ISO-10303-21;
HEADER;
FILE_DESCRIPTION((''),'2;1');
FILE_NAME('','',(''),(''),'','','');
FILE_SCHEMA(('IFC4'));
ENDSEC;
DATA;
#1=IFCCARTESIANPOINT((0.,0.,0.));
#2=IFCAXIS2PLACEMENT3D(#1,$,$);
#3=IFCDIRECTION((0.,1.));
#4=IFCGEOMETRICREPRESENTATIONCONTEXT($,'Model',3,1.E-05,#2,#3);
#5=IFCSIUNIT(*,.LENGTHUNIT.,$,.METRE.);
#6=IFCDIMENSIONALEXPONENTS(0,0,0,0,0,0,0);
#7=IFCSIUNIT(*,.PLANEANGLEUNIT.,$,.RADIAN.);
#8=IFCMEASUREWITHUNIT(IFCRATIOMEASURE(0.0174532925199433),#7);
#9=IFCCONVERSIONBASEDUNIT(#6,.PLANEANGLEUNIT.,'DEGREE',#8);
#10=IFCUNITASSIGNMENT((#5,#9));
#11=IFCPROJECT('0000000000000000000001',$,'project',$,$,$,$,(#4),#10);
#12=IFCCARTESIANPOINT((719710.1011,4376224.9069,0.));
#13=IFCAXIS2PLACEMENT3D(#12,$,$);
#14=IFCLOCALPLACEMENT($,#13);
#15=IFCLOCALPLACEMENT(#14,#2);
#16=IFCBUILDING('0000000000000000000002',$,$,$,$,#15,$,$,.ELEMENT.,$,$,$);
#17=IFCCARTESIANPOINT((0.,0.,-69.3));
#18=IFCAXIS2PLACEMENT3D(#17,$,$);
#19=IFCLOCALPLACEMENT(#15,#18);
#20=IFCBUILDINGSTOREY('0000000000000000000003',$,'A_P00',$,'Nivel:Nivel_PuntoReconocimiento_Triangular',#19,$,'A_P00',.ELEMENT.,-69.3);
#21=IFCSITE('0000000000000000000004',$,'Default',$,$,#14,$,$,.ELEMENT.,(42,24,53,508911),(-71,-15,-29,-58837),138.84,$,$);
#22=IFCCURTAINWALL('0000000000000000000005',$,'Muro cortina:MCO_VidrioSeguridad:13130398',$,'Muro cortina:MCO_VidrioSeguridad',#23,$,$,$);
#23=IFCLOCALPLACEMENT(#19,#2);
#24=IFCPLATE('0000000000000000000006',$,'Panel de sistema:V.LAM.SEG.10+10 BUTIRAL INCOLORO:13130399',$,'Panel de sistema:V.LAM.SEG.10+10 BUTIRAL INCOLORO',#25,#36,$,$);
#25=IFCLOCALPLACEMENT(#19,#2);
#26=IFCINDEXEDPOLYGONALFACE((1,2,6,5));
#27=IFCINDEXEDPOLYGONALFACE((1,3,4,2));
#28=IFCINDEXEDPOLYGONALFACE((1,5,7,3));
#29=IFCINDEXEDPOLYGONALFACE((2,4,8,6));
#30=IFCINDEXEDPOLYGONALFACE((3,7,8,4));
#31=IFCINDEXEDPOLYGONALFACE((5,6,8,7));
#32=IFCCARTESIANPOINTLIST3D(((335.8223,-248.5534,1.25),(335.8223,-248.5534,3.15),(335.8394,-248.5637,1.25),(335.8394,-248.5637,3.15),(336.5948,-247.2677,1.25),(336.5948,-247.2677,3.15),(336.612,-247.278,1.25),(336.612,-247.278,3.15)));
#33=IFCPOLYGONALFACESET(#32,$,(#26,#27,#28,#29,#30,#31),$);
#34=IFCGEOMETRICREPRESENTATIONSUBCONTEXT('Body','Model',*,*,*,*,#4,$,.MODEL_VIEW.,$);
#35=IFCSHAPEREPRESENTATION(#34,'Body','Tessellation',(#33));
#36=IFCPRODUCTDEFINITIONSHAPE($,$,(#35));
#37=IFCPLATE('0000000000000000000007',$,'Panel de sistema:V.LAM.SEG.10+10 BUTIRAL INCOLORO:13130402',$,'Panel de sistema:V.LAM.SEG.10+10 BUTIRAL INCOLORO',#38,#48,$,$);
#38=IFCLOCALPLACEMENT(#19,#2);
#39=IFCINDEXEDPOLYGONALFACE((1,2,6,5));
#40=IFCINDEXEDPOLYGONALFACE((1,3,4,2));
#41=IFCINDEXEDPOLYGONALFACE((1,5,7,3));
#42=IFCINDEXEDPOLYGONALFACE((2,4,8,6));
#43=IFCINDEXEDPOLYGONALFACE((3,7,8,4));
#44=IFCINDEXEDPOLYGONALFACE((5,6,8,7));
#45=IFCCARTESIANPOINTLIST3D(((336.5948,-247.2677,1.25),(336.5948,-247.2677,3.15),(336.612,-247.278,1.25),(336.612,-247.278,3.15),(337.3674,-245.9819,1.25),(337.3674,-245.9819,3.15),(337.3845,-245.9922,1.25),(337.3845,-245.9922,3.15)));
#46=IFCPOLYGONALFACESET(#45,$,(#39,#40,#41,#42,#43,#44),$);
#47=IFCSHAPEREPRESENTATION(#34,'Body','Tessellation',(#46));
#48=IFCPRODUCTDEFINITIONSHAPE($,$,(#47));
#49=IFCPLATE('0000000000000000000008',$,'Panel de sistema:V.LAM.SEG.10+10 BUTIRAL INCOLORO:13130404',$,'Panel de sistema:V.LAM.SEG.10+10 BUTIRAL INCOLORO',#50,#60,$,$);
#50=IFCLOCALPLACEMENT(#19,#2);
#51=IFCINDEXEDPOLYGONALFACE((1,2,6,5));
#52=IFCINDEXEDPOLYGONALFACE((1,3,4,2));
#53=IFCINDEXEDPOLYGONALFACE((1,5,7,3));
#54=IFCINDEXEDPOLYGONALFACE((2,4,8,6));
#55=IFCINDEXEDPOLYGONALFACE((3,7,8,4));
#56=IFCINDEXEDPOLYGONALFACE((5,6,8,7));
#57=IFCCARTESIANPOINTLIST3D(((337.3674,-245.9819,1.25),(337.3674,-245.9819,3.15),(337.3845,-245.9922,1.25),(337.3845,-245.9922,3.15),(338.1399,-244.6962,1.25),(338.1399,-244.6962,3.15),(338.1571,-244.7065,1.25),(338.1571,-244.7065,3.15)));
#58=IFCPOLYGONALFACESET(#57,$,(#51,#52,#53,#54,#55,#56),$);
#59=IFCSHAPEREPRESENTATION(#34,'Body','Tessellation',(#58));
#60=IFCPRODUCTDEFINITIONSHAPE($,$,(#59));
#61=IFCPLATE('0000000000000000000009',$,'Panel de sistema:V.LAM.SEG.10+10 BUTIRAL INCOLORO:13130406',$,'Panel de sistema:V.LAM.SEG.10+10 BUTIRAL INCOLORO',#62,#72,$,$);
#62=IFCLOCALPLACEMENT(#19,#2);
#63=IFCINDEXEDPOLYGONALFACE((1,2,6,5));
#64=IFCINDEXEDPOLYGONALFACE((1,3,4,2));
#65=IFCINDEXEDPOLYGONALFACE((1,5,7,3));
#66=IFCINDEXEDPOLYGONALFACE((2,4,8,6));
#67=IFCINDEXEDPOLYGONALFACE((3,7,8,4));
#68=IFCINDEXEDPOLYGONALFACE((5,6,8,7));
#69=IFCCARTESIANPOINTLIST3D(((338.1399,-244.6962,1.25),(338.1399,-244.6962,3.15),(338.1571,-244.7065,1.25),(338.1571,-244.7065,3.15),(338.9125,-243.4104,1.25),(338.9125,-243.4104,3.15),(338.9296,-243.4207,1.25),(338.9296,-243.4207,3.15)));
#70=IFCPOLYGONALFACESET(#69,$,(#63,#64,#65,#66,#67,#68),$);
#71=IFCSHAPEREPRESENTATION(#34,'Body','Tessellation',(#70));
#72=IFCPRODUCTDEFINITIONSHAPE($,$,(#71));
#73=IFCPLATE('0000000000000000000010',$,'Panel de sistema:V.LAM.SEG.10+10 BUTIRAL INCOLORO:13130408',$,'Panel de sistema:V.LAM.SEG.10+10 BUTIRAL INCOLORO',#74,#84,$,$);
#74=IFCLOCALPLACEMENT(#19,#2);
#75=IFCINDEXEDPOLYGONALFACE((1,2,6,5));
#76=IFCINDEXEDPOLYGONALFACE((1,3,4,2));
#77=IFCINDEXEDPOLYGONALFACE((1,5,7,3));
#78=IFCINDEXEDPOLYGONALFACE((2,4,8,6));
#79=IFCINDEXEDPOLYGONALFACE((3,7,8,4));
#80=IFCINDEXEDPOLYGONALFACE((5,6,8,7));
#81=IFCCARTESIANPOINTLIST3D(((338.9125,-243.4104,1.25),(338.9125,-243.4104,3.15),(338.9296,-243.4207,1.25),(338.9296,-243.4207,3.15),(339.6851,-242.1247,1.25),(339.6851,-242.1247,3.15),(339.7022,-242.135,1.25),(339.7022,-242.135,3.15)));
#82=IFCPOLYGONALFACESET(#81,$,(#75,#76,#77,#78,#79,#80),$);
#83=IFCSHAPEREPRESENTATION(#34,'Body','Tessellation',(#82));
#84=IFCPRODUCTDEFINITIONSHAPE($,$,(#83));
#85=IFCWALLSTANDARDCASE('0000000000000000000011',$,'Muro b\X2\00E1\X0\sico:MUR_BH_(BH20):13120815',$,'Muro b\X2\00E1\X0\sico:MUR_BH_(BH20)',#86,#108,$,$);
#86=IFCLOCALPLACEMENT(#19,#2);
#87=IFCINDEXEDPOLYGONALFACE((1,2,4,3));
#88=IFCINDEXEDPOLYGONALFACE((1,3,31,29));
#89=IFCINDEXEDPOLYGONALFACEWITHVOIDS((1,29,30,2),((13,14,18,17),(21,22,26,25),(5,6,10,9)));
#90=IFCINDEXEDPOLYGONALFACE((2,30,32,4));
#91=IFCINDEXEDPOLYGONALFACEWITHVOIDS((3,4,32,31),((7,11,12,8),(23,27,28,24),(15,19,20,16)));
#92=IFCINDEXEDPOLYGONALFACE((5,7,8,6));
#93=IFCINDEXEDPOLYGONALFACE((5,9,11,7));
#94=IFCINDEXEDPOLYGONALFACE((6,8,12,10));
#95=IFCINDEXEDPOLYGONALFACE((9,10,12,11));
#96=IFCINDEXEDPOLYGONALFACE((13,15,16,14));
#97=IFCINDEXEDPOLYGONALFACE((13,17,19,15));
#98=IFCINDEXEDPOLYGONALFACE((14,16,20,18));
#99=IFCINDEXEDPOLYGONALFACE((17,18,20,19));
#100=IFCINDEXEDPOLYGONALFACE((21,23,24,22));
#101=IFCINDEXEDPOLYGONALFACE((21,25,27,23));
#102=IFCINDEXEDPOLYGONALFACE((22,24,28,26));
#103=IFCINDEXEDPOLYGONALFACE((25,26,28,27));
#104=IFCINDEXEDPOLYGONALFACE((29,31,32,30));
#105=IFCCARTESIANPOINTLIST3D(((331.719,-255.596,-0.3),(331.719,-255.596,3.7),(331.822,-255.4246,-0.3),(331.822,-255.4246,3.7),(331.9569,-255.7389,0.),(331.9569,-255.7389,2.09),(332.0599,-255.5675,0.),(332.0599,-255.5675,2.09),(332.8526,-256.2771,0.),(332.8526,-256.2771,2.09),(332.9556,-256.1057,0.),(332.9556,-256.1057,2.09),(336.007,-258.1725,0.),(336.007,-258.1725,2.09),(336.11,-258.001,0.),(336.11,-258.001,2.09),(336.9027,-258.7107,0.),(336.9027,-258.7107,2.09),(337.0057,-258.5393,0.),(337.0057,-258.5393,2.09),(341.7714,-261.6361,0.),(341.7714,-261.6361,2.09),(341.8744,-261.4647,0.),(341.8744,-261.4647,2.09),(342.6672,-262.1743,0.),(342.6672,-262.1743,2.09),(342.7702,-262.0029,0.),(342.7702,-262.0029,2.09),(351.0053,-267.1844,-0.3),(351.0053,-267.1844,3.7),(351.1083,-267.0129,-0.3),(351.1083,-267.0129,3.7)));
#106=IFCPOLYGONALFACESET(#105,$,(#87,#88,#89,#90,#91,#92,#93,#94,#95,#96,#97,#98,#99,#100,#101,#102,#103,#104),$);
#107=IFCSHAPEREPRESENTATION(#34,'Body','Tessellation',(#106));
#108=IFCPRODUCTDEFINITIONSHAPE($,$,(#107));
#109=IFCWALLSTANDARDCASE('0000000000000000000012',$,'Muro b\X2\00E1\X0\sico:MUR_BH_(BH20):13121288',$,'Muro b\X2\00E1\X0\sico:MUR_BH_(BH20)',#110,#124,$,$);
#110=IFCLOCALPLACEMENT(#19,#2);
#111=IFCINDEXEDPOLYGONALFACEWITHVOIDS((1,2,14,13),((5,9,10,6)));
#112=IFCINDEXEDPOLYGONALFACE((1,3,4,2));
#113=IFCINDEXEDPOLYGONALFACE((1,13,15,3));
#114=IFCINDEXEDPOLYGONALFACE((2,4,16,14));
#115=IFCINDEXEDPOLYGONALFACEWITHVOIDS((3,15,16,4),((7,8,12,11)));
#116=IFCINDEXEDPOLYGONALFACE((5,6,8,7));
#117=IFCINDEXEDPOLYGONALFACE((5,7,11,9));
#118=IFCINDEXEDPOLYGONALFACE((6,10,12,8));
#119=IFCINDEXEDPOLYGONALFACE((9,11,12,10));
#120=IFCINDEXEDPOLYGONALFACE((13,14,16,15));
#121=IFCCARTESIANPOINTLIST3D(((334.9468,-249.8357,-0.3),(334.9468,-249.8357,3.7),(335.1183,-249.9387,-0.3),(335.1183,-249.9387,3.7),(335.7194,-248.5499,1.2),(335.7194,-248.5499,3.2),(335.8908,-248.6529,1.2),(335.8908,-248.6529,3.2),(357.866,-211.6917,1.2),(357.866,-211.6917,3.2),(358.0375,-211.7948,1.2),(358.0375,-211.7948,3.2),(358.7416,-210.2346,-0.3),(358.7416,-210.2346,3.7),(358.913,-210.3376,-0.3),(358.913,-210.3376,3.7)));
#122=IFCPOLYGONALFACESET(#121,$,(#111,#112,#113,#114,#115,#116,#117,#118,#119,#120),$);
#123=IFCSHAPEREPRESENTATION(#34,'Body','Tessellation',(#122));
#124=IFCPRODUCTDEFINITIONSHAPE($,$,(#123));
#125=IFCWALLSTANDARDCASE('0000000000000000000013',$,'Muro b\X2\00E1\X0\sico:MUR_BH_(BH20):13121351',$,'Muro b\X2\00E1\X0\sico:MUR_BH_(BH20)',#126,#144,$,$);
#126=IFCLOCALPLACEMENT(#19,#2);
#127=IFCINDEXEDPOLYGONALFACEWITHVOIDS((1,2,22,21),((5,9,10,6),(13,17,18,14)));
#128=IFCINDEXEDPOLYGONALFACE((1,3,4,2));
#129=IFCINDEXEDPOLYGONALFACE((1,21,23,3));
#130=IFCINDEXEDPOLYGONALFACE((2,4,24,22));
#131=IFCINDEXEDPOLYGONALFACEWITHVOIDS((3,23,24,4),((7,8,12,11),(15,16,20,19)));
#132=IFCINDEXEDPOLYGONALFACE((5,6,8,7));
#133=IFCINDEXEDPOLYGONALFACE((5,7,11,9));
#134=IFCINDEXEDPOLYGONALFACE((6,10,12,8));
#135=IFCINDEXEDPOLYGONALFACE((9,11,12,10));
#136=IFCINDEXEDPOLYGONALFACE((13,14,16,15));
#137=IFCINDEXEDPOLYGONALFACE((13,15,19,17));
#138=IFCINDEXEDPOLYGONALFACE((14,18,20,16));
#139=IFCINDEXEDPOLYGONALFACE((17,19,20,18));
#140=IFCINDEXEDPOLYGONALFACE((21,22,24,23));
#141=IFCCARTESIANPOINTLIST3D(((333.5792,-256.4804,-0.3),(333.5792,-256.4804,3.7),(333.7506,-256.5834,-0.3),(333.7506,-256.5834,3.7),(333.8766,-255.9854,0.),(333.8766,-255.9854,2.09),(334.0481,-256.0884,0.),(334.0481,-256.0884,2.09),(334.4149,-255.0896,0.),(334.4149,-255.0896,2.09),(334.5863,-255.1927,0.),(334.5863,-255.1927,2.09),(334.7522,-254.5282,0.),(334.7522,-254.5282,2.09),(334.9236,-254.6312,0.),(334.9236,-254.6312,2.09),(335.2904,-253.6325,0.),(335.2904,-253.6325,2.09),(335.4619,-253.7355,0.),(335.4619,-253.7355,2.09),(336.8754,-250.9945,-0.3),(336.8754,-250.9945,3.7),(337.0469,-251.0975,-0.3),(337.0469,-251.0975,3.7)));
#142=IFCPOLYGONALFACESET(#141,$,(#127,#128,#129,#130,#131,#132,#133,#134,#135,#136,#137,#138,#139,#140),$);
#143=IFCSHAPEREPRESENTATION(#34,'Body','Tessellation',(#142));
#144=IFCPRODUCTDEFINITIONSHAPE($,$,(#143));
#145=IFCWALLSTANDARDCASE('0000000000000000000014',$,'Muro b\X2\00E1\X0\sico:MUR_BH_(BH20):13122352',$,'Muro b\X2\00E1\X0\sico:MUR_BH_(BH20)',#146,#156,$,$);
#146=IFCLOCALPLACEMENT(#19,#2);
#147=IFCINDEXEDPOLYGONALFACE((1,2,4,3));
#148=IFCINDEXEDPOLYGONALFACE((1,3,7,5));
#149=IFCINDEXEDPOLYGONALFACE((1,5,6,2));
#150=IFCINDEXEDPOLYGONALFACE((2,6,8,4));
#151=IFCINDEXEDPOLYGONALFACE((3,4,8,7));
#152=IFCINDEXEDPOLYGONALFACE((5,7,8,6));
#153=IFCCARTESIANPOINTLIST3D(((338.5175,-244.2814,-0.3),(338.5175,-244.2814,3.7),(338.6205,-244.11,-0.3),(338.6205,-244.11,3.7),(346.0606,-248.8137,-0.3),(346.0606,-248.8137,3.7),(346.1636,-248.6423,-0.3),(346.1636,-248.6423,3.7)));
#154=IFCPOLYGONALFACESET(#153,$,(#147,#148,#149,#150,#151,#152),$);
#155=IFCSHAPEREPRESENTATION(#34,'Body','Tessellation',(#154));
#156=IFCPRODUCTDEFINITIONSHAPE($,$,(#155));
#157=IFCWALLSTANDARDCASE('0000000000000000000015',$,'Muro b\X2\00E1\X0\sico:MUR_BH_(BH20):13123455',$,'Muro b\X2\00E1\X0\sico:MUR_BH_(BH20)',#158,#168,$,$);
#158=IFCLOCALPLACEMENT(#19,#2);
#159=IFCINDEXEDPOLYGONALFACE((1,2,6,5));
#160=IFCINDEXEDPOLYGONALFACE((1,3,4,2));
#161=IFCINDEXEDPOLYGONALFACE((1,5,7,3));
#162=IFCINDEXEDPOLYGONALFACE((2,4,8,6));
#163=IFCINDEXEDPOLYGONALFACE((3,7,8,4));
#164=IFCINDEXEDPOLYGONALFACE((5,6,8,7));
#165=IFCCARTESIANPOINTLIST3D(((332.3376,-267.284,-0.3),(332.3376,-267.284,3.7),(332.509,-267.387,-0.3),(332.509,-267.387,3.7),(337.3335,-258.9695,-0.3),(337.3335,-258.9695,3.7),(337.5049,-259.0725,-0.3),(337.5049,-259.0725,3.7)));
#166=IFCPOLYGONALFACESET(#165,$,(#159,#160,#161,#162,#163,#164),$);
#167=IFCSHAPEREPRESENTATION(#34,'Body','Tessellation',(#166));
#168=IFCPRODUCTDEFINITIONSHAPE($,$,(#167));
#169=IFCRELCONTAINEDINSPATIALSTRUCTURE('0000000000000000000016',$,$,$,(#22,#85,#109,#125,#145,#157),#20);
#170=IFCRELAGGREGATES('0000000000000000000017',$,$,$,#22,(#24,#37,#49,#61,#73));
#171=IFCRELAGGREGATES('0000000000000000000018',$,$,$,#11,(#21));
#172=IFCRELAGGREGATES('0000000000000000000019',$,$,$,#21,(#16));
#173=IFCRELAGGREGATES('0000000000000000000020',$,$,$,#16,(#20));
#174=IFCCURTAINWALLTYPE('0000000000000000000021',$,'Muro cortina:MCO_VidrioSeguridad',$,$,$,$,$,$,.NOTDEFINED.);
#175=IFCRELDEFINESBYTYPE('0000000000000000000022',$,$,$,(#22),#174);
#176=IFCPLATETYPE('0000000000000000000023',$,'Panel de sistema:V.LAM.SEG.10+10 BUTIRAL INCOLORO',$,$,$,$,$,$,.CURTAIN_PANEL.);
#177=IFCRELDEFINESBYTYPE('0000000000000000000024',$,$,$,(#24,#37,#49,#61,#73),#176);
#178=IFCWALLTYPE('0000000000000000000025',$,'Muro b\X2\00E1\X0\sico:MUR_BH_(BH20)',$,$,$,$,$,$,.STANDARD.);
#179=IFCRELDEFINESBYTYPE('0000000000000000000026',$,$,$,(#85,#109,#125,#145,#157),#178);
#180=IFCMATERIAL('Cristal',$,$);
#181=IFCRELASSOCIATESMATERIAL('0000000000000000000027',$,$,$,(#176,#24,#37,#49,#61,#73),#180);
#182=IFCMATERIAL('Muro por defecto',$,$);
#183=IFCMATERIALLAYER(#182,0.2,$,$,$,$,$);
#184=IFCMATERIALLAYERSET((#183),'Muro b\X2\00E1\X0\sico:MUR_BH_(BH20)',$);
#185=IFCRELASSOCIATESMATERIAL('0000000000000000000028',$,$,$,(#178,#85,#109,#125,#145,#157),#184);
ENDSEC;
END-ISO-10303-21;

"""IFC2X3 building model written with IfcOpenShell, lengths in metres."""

from ifc_helpers import new_model, entity, si_unit, converted_unit, direction, frame, frame_2d, origin, origin_2d_with_axis, place, context, subcontext, project, spatial, rectangle, extrude, source, transform, mapped, material, layer, layer_set, layer_usage, type_object, type_shapes, element, aggregate, save


model = new_model("IFC2X3")

# Units and contexts
model_context = context("Model", 3, precision=1e-05, world=origin(), true_north=direction((0.0, 1.0)))
body_context = subcontext(model_context, "Body", "Model", "MODEL_VIEW")
ifc_project = project(units=[si_unit("LENGTHUNIT", "METRE"), converted_unit("PLANEANGLEUNIT", "DEGREE", entity("IfcRatioMeasure", 0.0174532925199433), si_unit("PLANEANGLEUNIT", "RADIAN"), dimensions=[0, 0, 0, 0, 0, 0, 0])], contexts=[model_context])

# Site, building, storey
site_placement = place(None, frame((719710.1011, 4376224.9069, 0.0)))
site = spatial("IfcSite", under=ifc_project, at=site_placement, Name="Default", CompositionType="ELEMENT", RefLatitude=(42, 24, 53, 508911), RefLongitude=(-71, -15, -29, -58837), RefElevation=138.84)
building_placement = place(site_placement, origin())
building = spatial("IfcBuilding", under=site, at=building_placement, CompositionType="ELEMENT")
storey_placement = place(building_placement, frame((0.0, 0.0, -69.3)))
storey = spatial("IfcBuildingStorey", under=building, at=storey_placement, Name="A_P00", ObjectType="Nivel:Nivel_PuntoReconocimiento_Triangular", LongName="A_P00", CompositionType="ELEMENT", Elevation=-69.3)

# Curtain wall, plates
curtain_wall_type = type_object("IfcCurtainWallType", Name="Muro cortina:MCO_VidrioSeguridad", PredefinedType="NOTDEFINED")
curtain_wall_placement = place(storey_placement, frame((0.0, 0.0, 69.3)))
curtain_wall = element("IfcCurtainWall", 1, at=curtain_wall_placement, inside=storey, type_object=curtain_wall_type, Name="Muro cortina:MCO_VidrioSeguridad:13130398", ObjectType="Muro cortina:MCO_VidrioSeguridad")
ifc_material_1 = material(Name="Cristal")
plate_type = type_object("IfcPlateType", Name="Panel de sistema:V.LAM.SEG.10+10 BUTIRAL INCOLORO", PredefinedType="CURTAIN_PANEL", material=ifc_material_1)
shared_shape = source(origin(), body_context, "Body", "SweptSolid", [
    extrude(rectangle(XDim=0.02, YDim=1.5, at=origin_2d_with_axis()), frame((0.0, 0.0, 0.0), z_axis=(0.0, 0.0, 1.0), x_axis=(0.0, 1.0, 0.0)), (0.0, 0.0, 1.0), 1.9),
])
type_shapes(plate_type, [shared_shape])
plate_1_placement = place(curtain_wall_placement, frame((336.2171, -247.9157, -68.05), z_axis=(0.0, 0.0, 1.0), x_axis=(0.515038, 0.857167, 0.0)))
plate_1 = element("IfcPlate", 2, at=plate_1_placement, type_object=plate_type, material=ifc_material_1, Name="Panel de sistema:V.LAM.SEG.10+10 BUTIRAL INCOLORO:13130399", ObjectType="Panel de sistema:V.LAM.SEG.10+10 BUTIRAL INCOLORO", context=body_context, shape_type="MappedRepresentation", body=[
    mapped(shared_shape, transform((0.0, 0.0, 0.0), scale=1.0)),
])
plate_2_placement = place(curtain_wall_placement, frame((336.9897, -246.63, -68.05), z_axis=(0.0, 0.0, 1.0), x_axis=(0.515038, 0.857167, 0.0)))
plate_2 = element("IfcPlate", 3, at=plate_2_placement, type_object=plate_type, material=ifc_material_1, Name="Panel de sistema:V.LAM.SEG.10+10 BUTIRAL INCOLORO:13130402", ObjectType="Panel de sistema:V.LAM.SEG.10+10 BUTIRAL INCOLORO", context=body_context, shape_type="MappedRepresentation", body=[
    mapped(shared_shape, transform((0.0, 0.0, 0.0), scale=1.0)),
])
plate_3_placement = place(curtain_wall_placement, frame((337.7622, -245.3442, -68.05), z_axis=(0.0, 0.0, 1.0), x_axis=(0.515038, 0.857167, 0.0)))
plate_3 = element("IfcPlate", 4, at=plate_3_placement, type_object=plate_type, material=ifc_material_1, Name="Panel de sistema:V.LAM.SEG.10+10 BUTIRAL INCOLORO:13130404", ObjectType="Panel de sistema:V.LAM.SEG.10+10 BUTIRAL INCOLORO", context=body_context, shape_type="MappedRepresentation", body=[
    mapped(shared_shape, transform((0.0, 0.0, 0.0), scale=1.0)),
])
plate_4_placement = place(curtain_wall_placement, frame((338.5348, -244.0585, -68.05), z_axis=(0.0, 0.0, 1.0), x_axis=(0.515038, 0.857167, 0.0)))
plate_4 = element("IfcPlate", 5, at=plate_4_placement, type_object=plate_type, material=ifc_material_1, Name="Panel de sistema:V.LAM.SEG.10+10 BUTIRAL INCOLORO:13130406", ObjectType="Panel de sistema:V.LAM.SEG.10+10 BUTIRAL INCOLORO", context=body_context, shape_type="MappedRepresentation", body=[
    mapped(shared_shape, transform((0.0, 0.0, 0.0), scale=1.0)),
])
plate_5_placement = place(curtain_wall_placement, frame((339.3074, -242.7727, -68.05), z_axis=(0.0, 0.0, 1.0), x_axis=(0.515038, 0.857167, 0.0)))
plate_5 = element("IfcPlate", 6, at=plate_5_placement, type_object=plate_type, material=ifc_material_1, Name="Panel de sistema:V.LAM.SEG.10+10 BUTIRAL INCOLORO:13130408", ObjectType="Panel de sistema:V.LAM.SEG.10+10 BUTIRAL INCOLORO", context=body_context, shape_type="MappedRepresentation", body=[
    mapped(shared_shape, transform((0.0, 0.0, 0.0), scale=1.0)),
])
aggregate(curtain_wall, [plate_1, plate_2, plate_3, plate_4, plate_5])

# Wall, openings
ifc_material_2 = material(Name="Muro por defecto")
ifc_layer = layer(ifc_material_2, 0.2)
ifc_layer_set = layer_set([ifc_layer], Name="Muro básico:MUR_BH_(BH20)")
ifc_layer_usage_1 = layer_usage(ifc_layer_set, "AXIS2", "NEGATIVE", 0.1)
wall_type = type_object("IfcWallType", Name="Muro básico:MUR_BH_(BH20)", PredefinedType="STANDARD", material=ifc_layer_set)
wall_1_placement = place(storey_placement, frame((331.7705, -255.5103, -0.3), z_axis=(0.0, 0.0, 1.0), x_axis=(0.857167, -0.515038, 0.0)))
wall_1 = element("IfcWallStandardCase", 7, at=wall_1_placement, inside=storey, type_object=wall_type, material=ifc_layer_usage_1, Name="Muro básico:MUR_BH_(BH20):13120815", ObjectType="Muro básico:MUR_BH_(BH20)", context=body_context, shape_type="SweptSolid", body=[
    extrude(rectangle(XDim=22.5, YDim=0.2, at=frame_2d((11.25, 0.0), x_axis=(-1.0, 0.0))), origin(), (0.0, 0.0, 1.0), 4.0),
])
opening_1_placement = place(wall_1_placement, frame((-415.9804, 48.1406, 0.3), z_axis=(0.0, 0.0, 1.0), x_axis=(0.857167, 0.515038, 0.0)))
element("IfcOpeningElement", 8, at=opening_1_placement, cuts=wall_1, ObjectType="Opening", context=body_context, shape_type="SweptSolid", body=[
    extrude(rectangle(XDim=2.09, YDim=1.045, at=frame_2d((0.0, 0.0), x_axis=(1.0, 0.0))), frame((336.4549, -258.4416, 1.045), z_axis=(0.515038, 0.857167, 0.0), x_axis=(0.0, 0.0, -1.0)), (0.0, 0.0, 1.0), 0.2),
])
opening_2_placement = place(wall_1_placement, frame((-415.9804, 48.1406, 0.3), z_axis=(0.0, 0.0, 1.0), x_axis=(0.857167, 0.515038, 0.0)))
element("IfcOpeningElement", 9, at=opening_2_placement, cuts=wall_1, ObjectType="Opening", context=body_context, shape_type="SweptSolid", body=[
    extrude(rectangle(XDim=2.09, YDim=1.045, at=frame_2d((0.0, 0.0), x_axis=(0.0, 1.0))), frame((332.4047, -256.008, 1.045), z_axis=(0.515038, 0.857167, 0.0), x_axis=(0.857167, -0.515038, 0.0)), (0.0, 0.0, 1.0), 0.2),
])
opening_3_placement = place(wall_1_placement, frame((-415.9804, 48.1406, 0.3), z_axis=(0.0, 0.0, 1.0), x_axis=(0.857167, 0.515038, 0.0)))
element("IfcOpeningElement", 10, at=opening_3_placement, cuts=wall_1, ObjectType="Opening", context=body_context, shape_type="SweptSolid", body=[
    extrude(rectangle(XDim=2.09, YDim=1.045, at=frame_2d((0.0, 0.0), x_axis=(1.0, 0.0))), frame((342.2193, -261.9052, 1.045), z_axis=(0.515038, 0.857167, 0.0), x_axis=(0.0, 0.0, -1.0)), (0.0, 0.0, 1.0), 0.2),
])

# Wall, opening
ifc_layer_usage_2 = layer_usage(ifc_layer_set, "AXIS2", "NEGATIVE", 0.1)
wall_2_placement = place(storey_placement, frame((335.0325, -249.8872, -0.3), z_axis=(0.0, 0.0, 1.0), x_axis=(0.515038, 0.857167, 0.0)))
wall_2 = element("IfcWallStandardCase", 11, at=wall_2_placement, inside=storey, type_object=wall_type, material=ifc_layer_usage_2, Name="Muro básico:MUR_BH_(BH20):13121288", ObjectType="Muro básico:MUR_BH_(BH20)", context=body_context, shape_type="SweptSolid", body=[
    extrude(rectangle(XDim=46.2, YDim=0.2, at=frame_2d((23.1, 0.0), x_axis=(-1.0, 0.0))), origin(), (0.0, 0.0, 1.0), 4.0),
])
opening_4_placement = place(wall_2_placement, origin())
element("IfcOpeningElement", 12, at=opening_4_placement, cuts=wall_2, ObjectType="Opening", context=body_context, shape_type="SweptSolid", body=[
    extrude(rectangle(XDim=2.0, YDim=43.0, at=frame_2d((0.0, 0.0), x_axis=(1.0, 0.0))), frame((23.0, -0.2524, 2.5), z_axis=(0.0, 1.0, 0.0), x_axis=(0.0, 0.0, 1.0)), (0.0, 0.0, 1.0), 0.5048),
])

# Wall, openings
ifc_layer_usage_3 = layer_usage(ifc_layer_set, "AXIS2", "NEGATIVE", 0.1)
wall_3_placement = place(storey_placement, frame((333.6649, -256.5319, -0.3), z_axis=(0.0, 0.0, 1.0), x_axis=(0.515038, 0.857167, 0.0)))
wall_3 = element("IfcWallStandardCase", 13, at=wall_3_placement, inside=storey, type_object=wall_type, material=ifc_layer_usage_3, Name="Muro básico:MUR_BH_(BH20):13121351", ObjectType="Muro básico:MUR_BH_(BH20)", context=body_context, shape_type="SweptSolid", body=[
    extrude(rectangle(XDim=6.4, YDim=0.2, at=frame_2d((3.2, 0.0), x_axis=(-1.0, 0.0))), origin(), (0.0, 0.0, 1.0), 4.0),
])
opening_5_placement = place(wall_3_placement, frame((48.0406, 418.1304, 0.3), z_axis=(0.0, 0.0, 1.0), x_axis=(0.515038, -0.857167, 0.0)))
element("IfcOpeningElement", 14, at=opening_5_placement, cuts=wall_3, ObjectType="Opening", context=body_context, shape_type="SweptSolid", body=[
    extrude(rectangle(XDim=2.09, YDim=1.045, at=frame_2d((0.0, 0.0), x_axis=(0.0, 1.0))), frame((335.1927, -254.1833, 1.045), z_axis=(-0.857167, 0.515038, 0.0), x_axis=(0.515038, 0.857167, 0.0)), (0.0, 0.0, 1.0), 0.2),
])
opening_6_placement = place(wall_3_placement, frame((48.0406, 418.1304, 0.3), z_axis=(0.0, 0.0, 1.0), x_axis=(0.515038, -0.857167, 0.0)))
element("IfcOpeningElement", 15, at=opening_6_placement, cuts=wall_3, ObjectType="Opening", context=body_context, shape_type="SweptSolid", body=[
    extrude(rectangle(XDim=2.09, YDim=1.045, at=frame_2d((0.0, 0.0), x_axis=(1.0, 0.0))), frame((334.3172, -255.6405, 1.045), z_axis=(-0.857167, 0.515038, 0.0), x_axis=(0.0, 0.0, -1.0)), (0.0, 0.0, 1.0), 0.2),
])

# Walls
ifc_layer_usage_4 = layer_usage(ifc_layer_set, "AXIS2", "NEGATIVE", 0.1)
wall_4_placement = place(storey_placement, frame((338.569, -244.1957, -0.3), z_axis=(0.0, 0.0, 1.0), x_axis=(0.857167, -0.515038, 0.0)))
element("IfcWallStandardCase", 16, at=wall_4_placement, inside=storey, type_object=wall_type, material=ifc_layer_usage_4, Name="Muro básico:MUR_BH_(BH20):13122352", ObjectType="Muro básico:MUR_BH_(BH20)", context=body_context, shape_type="SweptSolid", body=[
    extrude(rectangle(XDim=8.8, YDim=0.2, at=frame_2d((4.4, 0.0), x_axis=(-1.0, 0.0))), origin(), (0.0, 0.0, 1.0), 4.0),
])
ifc_layer_usage_5 = layer_usage(ifc_layer_set, "AXIS2", "NEGATIVE", 0.1)
wall_5_placement = place(storey_placement, frame((332.4233, -267.3355, -0.3), z_axis=(0.0, 0.0, 1.0), x_axis=(0.515038, 0.857167, 0.0)))
element("IfcWallStandardCase", 17, at=wall_5_placement, inside=storey, type_object=wall_type, material=ifc_layer_usage_5, Name="Muro básico:MUR_BH_(BH20):13123455", ObjectType="Muro básico:MUR_BH_(BH20)", context=body_context, shape_type="SweptSolid", body=[
    extrude(rectangle(XDim=9.7, YDim=0.2, at=frame_2d((4.85, 0.0), x_axis=(-1.0, 0.0))), origin(), (0.0, 0.0, 1.0), 4.0),
])

save(model, "model.ifc")
